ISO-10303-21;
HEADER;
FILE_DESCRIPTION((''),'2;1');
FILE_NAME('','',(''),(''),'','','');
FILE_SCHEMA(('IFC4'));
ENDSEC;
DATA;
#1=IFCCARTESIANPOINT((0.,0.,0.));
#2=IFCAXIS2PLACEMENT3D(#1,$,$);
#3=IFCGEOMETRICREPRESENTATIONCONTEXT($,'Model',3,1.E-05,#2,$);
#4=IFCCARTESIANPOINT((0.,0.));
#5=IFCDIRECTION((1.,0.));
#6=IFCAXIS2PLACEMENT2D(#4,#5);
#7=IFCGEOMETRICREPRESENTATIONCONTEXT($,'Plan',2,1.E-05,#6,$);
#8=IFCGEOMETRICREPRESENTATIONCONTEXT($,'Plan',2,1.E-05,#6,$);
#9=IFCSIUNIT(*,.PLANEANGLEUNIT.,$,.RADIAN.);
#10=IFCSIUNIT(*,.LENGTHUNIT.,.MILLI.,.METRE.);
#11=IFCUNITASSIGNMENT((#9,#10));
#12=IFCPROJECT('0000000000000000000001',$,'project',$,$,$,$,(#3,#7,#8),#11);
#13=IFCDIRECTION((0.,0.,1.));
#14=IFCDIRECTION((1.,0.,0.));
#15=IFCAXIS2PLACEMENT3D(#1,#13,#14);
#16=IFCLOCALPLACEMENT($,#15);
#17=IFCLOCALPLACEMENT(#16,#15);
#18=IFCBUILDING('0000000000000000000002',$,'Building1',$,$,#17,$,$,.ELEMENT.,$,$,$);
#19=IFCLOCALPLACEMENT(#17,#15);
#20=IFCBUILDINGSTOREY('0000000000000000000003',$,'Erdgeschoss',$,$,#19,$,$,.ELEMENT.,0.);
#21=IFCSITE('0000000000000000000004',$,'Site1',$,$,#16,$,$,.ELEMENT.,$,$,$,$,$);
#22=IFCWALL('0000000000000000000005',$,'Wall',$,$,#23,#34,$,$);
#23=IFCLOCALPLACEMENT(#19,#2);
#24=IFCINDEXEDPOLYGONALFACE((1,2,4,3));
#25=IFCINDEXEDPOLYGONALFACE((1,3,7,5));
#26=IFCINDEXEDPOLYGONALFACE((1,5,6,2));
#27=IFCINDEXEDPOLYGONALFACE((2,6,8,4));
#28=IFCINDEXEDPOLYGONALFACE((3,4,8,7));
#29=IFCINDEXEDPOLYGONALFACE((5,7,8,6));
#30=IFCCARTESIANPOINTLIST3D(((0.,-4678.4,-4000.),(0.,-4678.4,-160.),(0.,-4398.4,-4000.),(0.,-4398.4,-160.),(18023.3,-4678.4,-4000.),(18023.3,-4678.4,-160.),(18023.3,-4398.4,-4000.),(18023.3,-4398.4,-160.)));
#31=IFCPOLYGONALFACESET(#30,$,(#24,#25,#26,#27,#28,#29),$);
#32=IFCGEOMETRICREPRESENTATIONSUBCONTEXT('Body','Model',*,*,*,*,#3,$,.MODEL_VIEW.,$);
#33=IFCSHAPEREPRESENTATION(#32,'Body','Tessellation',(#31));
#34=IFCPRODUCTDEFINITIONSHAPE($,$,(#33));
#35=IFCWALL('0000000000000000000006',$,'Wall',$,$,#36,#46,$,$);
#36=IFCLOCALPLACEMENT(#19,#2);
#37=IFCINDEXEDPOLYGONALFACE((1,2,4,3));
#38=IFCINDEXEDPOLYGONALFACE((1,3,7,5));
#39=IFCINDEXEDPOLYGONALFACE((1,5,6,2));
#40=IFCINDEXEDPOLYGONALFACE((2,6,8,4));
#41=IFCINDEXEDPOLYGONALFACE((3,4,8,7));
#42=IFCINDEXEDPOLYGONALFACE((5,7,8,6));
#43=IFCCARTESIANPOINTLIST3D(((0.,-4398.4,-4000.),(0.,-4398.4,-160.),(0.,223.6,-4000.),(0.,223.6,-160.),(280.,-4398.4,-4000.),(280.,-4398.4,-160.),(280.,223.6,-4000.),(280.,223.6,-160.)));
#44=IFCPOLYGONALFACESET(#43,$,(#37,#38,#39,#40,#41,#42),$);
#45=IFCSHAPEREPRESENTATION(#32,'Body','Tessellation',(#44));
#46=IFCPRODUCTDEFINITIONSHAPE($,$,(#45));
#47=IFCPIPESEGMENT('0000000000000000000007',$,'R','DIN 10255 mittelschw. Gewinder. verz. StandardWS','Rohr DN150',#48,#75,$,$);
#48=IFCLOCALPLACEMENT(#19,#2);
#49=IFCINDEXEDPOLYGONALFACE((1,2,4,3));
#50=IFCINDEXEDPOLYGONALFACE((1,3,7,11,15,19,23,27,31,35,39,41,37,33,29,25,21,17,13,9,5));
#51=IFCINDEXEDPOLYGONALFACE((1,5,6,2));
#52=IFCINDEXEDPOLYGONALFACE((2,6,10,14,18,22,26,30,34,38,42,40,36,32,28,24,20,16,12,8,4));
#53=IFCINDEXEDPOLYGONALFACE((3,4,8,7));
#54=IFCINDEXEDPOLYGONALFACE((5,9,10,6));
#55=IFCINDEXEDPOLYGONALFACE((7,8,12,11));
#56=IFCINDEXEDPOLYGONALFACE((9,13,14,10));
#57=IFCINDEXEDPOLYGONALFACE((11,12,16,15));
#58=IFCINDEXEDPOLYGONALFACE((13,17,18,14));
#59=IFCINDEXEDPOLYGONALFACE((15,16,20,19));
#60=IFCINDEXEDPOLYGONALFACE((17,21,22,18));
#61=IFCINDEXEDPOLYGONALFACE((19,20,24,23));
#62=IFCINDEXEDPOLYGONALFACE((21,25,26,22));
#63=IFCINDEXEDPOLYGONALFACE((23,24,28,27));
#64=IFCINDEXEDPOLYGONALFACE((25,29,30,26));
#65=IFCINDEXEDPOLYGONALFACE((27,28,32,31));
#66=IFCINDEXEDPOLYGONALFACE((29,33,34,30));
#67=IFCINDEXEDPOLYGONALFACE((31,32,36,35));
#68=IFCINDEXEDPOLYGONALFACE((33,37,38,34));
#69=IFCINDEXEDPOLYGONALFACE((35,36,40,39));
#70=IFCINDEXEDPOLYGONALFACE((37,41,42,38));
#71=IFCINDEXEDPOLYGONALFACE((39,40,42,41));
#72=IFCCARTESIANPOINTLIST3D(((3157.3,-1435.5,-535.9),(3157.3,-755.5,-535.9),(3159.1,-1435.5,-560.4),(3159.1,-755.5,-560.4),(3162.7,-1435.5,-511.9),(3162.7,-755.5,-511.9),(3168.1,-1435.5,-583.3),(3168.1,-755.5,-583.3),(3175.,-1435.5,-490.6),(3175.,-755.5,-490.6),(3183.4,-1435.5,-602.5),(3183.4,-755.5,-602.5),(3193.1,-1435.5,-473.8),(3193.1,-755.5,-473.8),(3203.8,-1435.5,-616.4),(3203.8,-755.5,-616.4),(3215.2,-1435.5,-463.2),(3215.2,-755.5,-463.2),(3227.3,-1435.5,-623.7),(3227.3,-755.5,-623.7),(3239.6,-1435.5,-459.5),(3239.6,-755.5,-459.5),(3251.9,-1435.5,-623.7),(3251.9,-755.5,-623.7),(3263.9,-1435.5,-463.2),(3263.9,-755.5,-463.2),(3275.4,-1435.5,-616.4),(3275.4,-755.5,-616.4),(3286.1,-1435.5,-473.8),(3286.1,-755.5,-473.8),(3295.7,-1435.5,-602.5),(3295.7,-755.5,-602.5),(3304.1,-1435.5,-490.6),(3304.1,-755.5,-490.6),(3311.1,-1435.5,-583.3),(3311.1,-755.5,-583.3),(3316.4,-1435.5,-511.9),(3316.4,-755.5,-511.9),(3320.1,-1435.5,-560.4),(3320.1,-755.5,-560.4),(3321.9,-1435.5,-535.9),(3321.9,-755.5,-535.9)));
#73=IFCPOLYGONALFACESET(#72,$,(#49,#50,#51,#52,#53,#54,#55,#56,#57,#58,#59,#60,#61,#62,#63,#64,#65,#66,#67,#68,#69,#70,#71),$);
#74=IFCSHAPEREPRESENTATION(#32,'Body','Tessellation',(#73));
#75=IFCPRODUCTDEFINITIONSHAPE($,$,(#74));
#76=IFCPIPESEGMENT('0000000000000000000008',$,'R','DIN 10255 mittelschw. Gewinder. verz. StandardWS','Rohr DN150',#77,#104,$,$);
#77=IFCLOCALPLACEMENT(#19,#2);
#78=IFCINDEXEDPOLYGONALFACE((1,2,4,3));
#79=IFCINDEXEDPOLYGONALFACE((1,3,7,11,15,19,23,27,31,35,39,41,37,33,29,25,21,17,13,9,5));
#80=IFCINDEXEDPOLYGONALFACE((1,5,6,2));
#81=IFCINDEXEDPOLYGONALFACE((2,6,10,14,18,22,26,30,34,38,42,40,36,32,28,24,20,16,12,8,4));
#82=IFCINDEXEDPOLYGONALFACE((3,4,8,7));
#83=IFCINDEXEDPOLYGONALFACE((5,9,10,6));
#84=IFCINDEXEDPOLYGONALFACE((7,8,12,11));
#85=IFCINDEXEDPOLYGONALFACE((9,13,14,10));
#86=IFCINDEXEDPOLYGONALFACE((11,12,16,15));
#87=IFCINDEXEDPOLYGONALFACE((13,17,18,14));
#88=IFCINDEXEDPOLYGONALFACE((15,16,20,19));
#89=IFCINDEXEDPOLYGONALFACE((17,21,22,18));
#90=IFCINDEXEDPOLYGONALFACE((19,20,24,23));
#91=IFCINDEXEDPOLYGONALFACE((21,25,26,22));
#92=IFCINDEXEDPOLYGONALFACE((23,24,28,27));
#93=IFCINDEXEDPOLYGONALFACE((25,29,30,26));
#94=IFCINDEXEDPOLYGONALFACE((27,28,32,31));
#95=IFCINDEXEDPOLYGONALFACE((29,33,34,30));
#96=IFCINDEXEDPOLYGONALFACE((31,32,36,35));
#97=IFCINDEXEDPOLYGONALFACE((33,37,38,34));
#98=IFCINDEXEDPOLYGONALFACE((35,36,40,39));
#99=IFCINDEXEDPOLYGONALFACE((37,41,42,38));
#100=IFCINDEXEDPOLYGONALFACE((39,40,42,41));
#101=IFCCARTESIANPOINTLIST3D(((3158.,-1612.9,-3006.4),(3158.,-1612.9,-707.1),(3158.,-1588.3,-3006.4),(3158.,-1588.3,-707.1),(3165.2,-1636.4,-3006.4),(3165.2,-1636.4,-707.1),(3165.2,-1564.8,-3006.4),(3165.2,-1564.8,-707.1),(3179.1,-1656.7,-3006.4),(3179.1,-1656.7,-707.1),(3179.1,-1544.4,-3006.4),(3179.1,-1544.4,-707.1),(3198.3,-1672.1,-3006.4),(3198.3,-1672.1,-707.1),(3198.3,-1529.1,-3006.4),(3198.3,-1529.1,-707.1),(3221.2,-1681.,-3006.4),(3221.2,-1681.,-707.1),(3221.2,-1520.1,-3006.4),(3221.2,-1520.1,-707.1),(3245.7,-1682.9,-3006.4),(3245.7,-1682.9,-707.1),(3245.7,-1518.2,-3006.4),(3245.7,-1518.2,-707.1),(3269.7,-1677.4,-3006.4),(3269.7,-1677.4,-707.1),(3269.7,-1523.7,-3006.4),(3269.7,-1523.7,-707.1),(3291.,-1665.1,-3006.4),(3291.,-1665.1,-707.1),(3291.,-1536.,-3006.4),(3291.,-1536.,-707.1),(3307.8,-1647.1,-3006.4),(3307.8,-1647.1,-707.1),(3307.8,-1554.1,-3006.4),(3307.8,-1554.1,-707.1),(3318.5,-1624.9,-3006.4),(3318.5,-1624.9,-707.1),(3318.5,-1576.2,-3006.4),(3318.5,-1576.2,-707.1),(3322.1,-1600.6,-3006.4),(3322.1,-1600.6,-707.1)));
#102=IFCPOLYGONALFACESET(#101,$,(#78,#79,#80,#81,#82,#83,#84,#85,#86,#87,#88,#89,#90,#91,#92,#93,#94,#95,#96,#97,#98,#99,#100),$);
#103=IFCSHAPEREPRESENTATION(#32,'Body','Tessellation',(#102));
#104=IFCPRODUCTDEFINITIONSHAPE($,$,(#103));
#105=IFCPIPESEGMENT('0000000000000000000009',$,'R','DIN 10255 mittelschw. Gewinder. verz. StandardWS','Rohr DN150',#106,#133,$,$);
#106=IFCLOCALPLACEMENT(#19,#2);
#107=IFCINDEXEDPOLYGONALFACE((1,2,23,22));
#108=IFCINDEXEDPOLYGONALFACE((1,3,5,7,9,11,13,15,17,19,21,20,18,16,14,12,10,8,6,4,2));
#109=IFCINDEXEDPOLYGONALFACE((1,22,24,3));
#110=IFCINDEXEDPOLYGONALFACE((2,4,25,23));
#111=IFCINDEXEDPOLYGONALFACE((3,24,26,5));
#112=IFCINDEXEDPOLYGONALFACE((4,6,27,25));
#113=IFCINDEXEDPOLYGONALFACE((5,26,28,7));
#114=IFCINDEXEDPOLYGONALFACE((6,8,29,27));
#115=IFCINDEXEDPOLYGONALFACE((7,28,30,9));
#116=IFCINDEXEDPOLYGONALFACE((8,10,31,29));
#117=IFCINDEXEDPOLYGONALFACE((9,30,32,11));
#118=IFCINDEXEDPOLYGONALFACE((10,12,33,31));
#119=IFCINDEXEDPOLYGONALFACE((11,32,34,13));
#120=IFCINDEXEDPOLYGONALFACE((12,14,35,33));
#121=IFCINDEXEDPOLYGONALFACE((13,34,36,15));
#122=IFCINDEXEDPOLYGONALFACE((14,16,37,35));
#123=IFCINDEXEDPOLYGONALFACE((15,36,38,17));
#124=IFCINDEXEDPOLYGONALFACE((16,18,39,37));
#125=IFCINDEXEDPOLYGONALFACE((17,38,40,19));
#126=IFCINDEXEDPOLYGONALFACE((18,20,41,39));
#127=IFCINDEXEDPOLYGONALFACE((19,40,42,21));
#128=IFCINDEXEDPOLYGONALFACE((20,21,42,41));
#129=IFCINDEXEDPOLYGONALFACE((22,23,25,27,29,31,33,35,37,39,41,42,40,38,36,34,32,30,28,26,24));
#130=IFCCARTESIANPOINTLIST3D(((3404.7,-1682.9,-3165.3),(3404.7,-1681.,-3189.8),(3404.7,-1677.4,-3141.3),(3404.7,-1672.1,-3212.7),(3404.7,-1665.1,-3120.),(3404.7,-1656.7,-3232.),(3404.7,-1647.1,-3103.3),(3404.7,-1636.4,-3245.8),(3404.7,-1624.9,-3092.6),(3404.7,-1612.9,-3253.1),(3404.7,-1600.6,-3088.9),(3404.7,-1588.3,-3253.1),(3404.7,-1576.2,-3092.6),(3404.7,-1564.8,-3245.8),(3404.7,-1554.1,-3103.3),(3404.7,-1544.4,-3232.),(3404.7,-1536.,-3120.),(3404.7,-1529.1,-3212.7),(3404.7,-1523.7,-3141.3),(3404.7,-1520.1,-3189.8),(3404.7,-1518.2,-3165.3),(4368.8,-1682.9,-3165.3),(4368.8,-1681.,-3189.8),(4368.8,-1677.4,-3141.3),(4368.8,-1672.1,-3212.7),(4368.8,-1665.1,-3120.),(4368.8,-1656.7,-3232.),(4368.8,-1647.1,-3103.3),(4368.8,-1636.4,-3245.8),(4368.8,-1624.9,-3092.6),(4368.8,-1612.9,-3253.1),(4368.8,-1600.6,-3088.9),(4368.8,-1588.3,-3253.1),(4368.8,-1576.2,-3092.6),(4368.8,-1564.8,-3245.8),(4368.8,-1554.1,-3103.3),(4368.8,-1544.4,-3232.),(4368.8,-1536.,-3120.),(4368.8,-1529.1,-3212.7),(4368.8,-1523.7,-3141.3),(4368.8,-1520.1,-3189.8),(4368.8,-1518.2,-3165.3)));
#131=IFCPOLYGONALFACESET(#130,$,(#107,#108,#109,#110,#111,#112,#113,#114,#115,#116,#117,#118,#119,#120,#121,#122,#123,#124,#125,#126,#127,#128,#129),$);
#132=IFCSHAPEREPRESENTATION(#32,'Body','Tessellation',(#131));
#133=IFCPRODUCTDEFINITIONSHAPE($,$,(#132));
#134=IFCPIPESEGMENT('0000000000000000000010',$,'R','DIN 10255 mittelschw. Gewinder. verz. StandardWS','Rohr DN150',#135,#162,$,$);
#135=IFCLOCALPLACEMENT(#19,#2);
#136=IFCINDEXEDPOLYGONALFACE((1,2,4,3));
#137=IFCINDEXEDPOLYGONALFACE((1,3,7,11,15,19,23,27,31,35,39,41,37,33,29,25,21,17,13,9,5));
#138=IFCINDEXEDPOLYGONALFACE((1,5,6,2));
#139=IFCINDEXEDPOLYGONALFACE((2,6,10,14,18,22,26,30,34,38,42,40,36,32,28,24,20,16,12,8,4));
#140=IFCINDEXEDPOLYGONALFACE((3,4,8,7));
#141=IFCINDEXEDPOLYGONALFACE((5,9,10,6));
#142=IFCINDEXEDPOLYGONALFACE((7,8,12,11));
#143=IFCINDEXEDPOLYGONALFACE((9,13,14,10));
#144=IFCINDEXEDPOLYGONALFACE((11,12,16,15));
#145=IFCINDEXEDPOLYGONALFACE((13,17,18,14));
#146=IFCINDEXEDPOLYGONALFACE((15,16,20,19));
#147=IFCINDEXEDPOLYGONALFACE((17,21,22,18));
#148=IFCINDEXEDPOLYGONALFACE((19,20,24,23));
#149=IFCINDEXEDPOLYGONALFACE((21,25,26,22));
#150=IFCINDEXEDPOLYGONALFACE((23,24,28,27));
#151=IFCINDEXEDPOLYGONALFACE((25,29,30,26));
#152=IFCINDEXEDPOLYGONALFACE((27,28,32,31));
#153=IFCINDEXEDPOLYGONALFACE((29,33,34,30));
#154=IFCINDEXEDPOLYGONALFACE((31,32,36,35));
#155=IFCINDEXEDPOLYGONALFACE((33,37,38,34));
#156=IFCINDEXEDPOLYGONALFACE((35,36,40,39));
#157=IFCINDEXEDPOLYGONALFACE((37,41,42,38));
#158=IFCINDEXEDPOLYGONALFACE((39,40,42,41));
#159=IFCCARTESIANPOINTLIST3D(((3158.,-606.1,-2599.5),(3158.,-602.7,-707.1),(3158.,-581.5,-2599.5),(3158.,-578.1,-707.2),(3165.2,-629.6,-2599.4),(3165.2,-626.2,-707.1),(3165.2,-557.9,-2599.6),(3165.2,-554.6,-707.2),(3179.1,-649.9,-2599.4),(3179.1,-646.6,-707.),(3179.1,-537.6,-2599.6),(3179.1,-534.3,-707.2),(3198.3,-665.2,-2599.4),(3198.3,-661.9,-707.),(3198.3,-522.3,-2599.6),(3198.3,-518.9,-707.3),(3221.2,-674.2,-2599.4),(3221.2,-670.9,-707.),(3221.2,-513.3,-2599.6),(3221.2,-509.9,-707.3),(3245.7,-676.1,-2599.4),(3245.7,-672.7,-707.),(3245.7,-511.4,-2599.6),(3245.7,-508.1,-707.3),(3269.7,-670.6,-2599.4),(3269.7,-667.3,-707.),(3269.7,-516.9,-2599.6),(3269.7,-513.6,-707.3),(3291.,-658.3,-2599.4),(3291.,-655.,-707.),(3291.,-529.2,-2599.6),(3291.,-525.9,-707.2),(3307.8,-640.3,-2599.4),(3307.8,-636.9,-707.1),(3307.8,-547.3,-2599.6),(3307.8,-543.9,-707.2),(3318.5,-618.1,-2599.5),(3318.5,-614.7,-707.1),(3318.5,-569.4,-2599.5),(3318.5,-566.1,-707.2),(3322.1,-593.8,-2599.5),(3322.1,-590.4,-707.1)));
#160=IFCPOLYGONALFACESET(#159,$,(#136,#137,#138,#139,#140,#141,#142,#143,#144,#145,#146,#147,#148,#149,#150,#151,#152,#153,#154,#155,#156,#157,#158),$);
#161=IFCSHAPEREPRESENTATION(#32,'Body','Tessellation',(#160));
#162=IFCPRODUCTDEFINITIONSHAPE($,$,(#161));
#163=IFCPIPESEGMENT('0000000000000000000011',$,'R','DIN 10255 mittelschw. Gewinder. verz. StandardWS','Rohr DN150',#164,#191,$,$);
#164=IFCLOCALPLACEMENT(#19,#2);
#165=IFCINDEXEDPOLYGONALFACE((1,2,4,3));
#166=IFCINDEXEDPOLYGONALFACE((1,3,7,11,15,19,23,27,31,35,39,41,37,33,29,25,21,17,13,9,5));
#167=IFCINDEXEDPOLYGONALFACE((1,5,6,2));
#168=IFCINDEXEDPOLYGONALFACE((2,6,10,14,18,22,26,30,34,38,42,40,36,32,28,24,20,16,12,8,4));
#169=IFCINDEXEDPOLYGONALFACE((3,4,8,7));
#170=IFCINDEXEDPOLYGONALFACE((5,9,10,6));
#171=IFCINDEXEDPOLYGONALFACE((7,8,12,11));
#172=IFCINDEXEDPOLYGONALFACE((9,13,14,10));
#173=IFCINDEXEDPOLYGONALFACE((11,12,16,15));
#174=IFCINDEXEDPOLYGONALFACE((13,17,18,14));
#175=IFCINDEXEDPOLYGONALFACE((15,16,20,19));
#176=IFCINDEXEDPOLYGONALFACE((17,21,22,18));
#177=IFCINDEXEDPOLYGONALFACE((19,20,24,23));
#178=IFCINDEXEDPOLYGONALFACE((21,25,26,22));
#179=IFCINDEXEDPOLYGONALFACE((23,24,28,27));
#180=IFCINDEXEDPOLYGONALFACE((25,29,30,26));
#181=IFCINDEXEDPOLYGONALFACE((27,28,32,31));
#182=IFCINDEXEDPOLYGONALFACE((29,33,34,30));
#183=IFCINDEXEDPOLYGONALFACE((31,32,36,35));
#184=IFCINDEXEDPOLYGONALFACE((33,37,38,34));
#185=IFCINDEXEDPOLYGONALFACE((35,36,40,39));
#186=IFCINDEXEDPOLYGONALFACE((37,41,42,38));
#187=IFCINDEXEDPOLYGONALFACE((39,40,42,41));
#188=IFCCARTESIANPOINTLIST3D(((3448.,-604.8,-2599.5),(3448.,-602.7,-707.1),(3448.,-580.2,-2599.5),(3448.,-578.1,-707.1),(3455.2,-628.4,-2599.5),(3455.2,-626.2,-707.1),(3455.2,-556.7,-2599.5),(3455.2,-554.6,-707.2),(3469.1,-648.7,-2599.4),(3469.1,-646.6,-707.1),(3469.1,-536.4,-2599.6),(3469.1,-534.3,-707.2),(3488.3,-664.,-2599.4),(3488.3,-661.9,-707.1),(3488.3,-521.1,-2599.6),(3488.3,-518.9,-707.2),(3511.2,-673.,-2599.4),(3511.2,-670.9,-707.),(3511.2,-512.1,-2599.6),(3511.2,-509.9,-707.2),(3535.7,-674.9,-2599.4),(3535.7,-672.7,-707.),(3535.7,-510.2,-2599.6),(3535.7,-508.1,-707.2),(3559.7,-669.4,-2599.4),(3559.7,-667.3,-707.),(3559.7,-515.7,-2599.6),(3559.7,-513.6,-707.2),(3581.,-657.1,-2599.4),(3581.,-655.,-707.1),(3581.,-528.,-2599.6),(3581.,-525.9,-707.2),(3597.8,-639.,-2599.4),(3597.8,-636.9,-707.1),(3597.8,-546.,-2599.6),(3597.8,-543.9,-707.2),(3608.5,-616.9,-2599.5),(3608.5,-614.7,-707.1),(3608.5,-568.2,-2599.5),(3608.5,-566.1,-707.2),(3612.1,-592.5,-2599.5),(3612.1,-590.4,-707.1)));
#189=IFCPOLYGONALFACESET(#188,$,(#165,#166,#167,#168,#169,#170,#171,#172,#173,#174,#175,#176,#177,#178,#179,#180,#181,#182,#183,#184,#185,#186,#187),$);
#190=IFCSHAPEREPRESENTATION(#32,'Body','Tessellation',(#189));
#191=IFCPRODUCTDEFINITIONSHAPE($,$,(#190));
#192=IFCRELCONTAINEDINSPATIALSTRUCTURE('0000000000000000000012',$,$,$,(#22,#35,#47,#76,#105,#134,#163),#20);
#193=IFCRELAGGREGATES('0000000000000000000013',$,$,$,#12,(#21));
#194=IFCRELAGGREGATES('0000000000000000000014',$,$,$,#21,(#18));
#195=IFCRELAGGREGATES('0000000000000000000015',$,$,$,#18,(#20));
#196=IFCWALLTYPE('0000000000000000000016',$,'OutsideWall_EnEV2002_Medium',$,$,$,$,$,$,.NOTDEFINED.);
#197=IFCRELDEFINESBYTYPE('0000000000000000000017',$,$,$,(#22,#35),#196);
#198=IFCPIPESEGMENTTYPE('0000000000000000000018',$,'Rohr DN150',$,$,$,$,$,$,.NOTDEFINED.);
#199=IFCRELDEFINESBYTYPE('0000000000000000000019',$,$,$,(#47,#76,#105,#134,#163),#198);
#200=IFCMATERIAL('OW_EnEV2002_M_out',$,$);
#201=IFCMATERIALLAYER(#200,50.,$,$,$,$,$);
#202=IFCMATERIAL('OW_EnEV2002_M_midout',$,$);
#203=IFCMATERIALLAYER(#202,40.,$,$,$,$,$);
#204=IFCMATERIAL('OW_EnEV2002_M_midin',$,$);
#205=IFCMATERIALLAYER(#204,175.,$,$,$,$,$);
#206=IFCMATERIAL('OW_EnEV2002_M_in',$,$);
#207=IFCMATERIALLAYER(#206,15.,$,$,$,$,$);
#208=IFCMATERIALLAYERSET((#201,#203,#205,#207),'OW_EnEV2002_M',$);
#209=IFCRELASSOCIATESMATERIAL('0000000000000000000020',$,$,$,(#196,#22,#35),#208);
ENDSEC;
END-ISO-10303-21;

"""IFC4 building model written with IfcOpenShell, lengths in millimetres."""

from ifc_helpers import new_model, si_unit, frame, origin, origin_with_axes, origin_2d_with_axis, place, context, subcontext, project, spatial, indexed_curve, circle, outline, extrude, material, layer, layer_set, layer_usage, type_object, element, save


model = new_model("IFC4")

# Units and contexts
model_context = context("Model", 3, precision=1e-05, world=origin())
plan_context_1 = context("Plan", 2, precision=1e-05, world=origin_2d_with_axis())
plan_context_2 = context("Plan", 2, precision=1e-05, world=origin_2d_with_axis())
body_context = subcontext(model_context, "Body", "Model", "MODEL_VIEW")
ifc_project = project(units=[si_unit("PLANEANGLEUNIT", "RADIAN"), si_unit("LENGTHUNIT", "METRE", prefix="MILLI")], contexts=[model_context, plan_context_1, plan_context_2])

# Site, building, storey
site_placement = place(None, origin_with_axes())
site = spatial("IfcSite", under=ifc_project, at=site_placement, Name="Site1", CompositionType="ELEMENT")
building_placement = place(site_placement, origin_with_axes())
building = spatial("IfcBuilding", under=site, at=building_placement, Name="Building1", CompositionType="ELEMENT")
storey_placement = place(building_placement, origin_with_axes())
storey = spatial("IfcBuildingStorey", under=building, at=storey_placement, Name="Erdgeschoss", CompositionType="ELEMENT", Elevation=0.0)

# Walls
ifc_material_1 = material(Name="OW_EnEV2002_M_out")
ifc_layer_1 = layer(ifc_material_1, 50.0)
ifc_material_2 = material(Name="OW_EnEV2002_M_midout")
ifc_layer_2 = layer(ifc_material_2, 40.0)
ifc_material_3 = material(Name="OW_EnEV2002_M_midin")
ifc_layer_3 = layer(ifc_material_3, 175.0)
ifc_material_4 = material(Name="OW_EnEV2002_M_in")
ifc_layer_4 = layer(ifc_material_4, 15.0)
ifc_layer_set = layer_set([ifc_layer_1, ifc_layer_2, ifc_layer_3, ifc_layer_4], Name="OW_EnEV2002_M")
ifc_layer_usage_1 = layer_usage(ifc_layer_set, "AXIS2", "POSITIVE", 0.0)
wall_type = type_object("IfcWallType", Name="OutsideWall_EnEV2002_Medium", PredefinedType="NOTDEFINED", material=ifc_layer_set)
wall_1_placement = place(storey_placement, frame((0.0, -4678.4, -4000.0), z_axis=(0.0, 0.0, 1.0), x_axis=(1.0, 0.0, 0.0)))
element("IfcWall", 1, at=wall_1_placement, inside=storey, type_object=wall_type, material=ifc_layer_usage_1, Name="Wall", context=body_context, shape_type="SweptSolid", body=[
    extrude(outline(indexed_curve([(0.0, 0.0), (0.0, 280.0), (18023.3, 280.0), (18023.3, 0.0), (0.0, 0.0)], self_intersect=False)), origin_with_axes(), (0.0, 0.0, 1.0), 3840.0),
])
ifc_layer_usage_2 = layer_usage(ifc_layer_set, "AXIS2", "POSITIVE", 0.0)
wall_2_placement = place(storey_placement, frame((280.0, -4398.4, -4000.0), z_axis=(0.0, 0.0, 1.0), x_axis=(0.0, 1.0, 0.0)))
element("IfcWall", 2, at=wall_2_placement, inside=storey, type_object=wall_type, material=ifc_layer_usage_2, Name="Wall", context=body_context, shape_type="SweptSolid", body=[
    extrude(outline(indexed_curve([(0.0, 0.0), (0.0, 280.0), (4622.0, 280.0), (4622.0, 0.0), (0.0, 0.0)], self_intersect=False)), origin_with_axes(), (0.0, 0.0, 1.0), 3840.0),
])

# Pipe segments
pipe_segment_type_1 = type_object("IfcPipeSegmentType", Name="Rohr DN150", PredefinedType="NOTDEFINED")
pipe_segment_1_placement = place(storey_placement, frame((3239.7, -1095.5, -542.0), z_axis=(0.0, 0.0, 1.0), x_axis=(1.0, 0.0, 0.0)))
element("IfcPipeSegment", 3, at=pipe_segment_1_placement, inside=storey, type_object=pipe_segment_type_1, Name="R", Description="DIN 10255 mittelschw. Gewinder. verz. StandardWS", ObjectType="Rohr DN150", context=body_context, shape_type="SolidModel", body=[
    extrude(circle(Radius=82.5, at=origin_2d_with_axis()), frame((-0.2, 340.0, 0.0), z_axis=(0.0, -1.0, 0.0), x_axis=(0.0, 0.0, 1.0)), (0.0, 0.0, 1.0), 680.0),
])
pipe_segment_2_placement = place(storey_placement, frame((3239.6, -1600.4, -1856.8), z_axis=(0.0, 0.0, 1.0), x_axis=(1.0, 0.0, 0.0)))
element("IfcPipeSegment", 4, at=pipe_segment_2_placement, inside=storey, type_object=pipe_segment_type_1, Name="R", Description="DIN 10255 mittelschw. Gewinder. verz. StandardWS", ObjectType="Rohr DN150", context=body_context, shape_type="SolidModel", body=[
    extrude(circle(Radius=82.5, at=origin_2d_with_axis()), frame((0.0, -0.2, 1149.6), z_axis=(0.0, 0.0, -1.0), x_axis=(1.0, 0.0, 0.0)), (0.0, 0.0, 1.0), 2299.2),
])
pipe_segment_3_placement = place(storey_placement, frame((3886.8, -1600.7, -3171.5), z_axis=(0.0, 0.0, 1.0), x_axis=(1.0, 0.0, 0.0)))
element("IfcPipeSegment", 5, at=pipe_segment_3_placement, inside=storey, type_object=pipe_segment_type_1, Name="R", Description="DIN 10255 mittelschw. Gewinder. verz. StandardWS", ObjectType="Rohr DN150", context=body_context, shape_type="SolidModel", body=[
    extrude(circle(Radius=82.5, at=origin_2d_with_axis()), frame((482.1, 0.1, 0.0), z_axis=(-1.0, 0.0, 0.0), x_axis=(0.0, 0.0, 1.0)), (0.0, 0.0, 1.0), 964.1),
])
pipe_segment_4_placement = place(storey_placement, frame((3239.6, -592.2, -1653.3), z_axis=(0.0, 0.0, 1.0), x_axis=(1.0, 0.0, 0.0)))
element("IfcPipeSegment", 6, at=pipe_segment_4_placement, inside=storey, type_object=pipe_segment_type_1, Name="R", Description="DIN 10255 mittelschw. Gewinder. verz. StandardWS", ObjectType="Rohr DN150", context=body_context, shape_type="SolidModel", body=[
    extrude(circle(Radius=82.5, at=origin_2d_with_axis()), frame((0.0, -1.5, -946.2), z_axis=(0.0, 0.001768, 0.999998), x_axis=(1.0, 0.0, 0.0)), (0.0, 0.0, 1.0), 1892.4),
])
pipe_segment_5_placement = place(storey_placement, frame((3529.6, -591.6, -1653.3), z_axis=(0.0, 0.0, 1.0), x_axis=(1.0, 0.0, 0.0)))
element("IfcPipeSegment", 7, at=pipe_segment_5_placement, inside=storey, type_object=pipe_segment_type_1, Name="R", Description="DIN 10255 mittelschw. Gewinder. verz. StandardWS", ObjectType="Rohr DN150", context=body_context, shape_type="SolidModel", body=[
    extrude(circle(Radius=82.5, at=origin_2d_with_axis()), frame((0.0, -0.9, -946.2), z_axis=(0.0, 0.001126, 0.999999), x_axis=(1.0, 0.0, 0.0)), (0.0, 0.0, 1.0), 1892.4),
])

save(model, "model.ifc")
